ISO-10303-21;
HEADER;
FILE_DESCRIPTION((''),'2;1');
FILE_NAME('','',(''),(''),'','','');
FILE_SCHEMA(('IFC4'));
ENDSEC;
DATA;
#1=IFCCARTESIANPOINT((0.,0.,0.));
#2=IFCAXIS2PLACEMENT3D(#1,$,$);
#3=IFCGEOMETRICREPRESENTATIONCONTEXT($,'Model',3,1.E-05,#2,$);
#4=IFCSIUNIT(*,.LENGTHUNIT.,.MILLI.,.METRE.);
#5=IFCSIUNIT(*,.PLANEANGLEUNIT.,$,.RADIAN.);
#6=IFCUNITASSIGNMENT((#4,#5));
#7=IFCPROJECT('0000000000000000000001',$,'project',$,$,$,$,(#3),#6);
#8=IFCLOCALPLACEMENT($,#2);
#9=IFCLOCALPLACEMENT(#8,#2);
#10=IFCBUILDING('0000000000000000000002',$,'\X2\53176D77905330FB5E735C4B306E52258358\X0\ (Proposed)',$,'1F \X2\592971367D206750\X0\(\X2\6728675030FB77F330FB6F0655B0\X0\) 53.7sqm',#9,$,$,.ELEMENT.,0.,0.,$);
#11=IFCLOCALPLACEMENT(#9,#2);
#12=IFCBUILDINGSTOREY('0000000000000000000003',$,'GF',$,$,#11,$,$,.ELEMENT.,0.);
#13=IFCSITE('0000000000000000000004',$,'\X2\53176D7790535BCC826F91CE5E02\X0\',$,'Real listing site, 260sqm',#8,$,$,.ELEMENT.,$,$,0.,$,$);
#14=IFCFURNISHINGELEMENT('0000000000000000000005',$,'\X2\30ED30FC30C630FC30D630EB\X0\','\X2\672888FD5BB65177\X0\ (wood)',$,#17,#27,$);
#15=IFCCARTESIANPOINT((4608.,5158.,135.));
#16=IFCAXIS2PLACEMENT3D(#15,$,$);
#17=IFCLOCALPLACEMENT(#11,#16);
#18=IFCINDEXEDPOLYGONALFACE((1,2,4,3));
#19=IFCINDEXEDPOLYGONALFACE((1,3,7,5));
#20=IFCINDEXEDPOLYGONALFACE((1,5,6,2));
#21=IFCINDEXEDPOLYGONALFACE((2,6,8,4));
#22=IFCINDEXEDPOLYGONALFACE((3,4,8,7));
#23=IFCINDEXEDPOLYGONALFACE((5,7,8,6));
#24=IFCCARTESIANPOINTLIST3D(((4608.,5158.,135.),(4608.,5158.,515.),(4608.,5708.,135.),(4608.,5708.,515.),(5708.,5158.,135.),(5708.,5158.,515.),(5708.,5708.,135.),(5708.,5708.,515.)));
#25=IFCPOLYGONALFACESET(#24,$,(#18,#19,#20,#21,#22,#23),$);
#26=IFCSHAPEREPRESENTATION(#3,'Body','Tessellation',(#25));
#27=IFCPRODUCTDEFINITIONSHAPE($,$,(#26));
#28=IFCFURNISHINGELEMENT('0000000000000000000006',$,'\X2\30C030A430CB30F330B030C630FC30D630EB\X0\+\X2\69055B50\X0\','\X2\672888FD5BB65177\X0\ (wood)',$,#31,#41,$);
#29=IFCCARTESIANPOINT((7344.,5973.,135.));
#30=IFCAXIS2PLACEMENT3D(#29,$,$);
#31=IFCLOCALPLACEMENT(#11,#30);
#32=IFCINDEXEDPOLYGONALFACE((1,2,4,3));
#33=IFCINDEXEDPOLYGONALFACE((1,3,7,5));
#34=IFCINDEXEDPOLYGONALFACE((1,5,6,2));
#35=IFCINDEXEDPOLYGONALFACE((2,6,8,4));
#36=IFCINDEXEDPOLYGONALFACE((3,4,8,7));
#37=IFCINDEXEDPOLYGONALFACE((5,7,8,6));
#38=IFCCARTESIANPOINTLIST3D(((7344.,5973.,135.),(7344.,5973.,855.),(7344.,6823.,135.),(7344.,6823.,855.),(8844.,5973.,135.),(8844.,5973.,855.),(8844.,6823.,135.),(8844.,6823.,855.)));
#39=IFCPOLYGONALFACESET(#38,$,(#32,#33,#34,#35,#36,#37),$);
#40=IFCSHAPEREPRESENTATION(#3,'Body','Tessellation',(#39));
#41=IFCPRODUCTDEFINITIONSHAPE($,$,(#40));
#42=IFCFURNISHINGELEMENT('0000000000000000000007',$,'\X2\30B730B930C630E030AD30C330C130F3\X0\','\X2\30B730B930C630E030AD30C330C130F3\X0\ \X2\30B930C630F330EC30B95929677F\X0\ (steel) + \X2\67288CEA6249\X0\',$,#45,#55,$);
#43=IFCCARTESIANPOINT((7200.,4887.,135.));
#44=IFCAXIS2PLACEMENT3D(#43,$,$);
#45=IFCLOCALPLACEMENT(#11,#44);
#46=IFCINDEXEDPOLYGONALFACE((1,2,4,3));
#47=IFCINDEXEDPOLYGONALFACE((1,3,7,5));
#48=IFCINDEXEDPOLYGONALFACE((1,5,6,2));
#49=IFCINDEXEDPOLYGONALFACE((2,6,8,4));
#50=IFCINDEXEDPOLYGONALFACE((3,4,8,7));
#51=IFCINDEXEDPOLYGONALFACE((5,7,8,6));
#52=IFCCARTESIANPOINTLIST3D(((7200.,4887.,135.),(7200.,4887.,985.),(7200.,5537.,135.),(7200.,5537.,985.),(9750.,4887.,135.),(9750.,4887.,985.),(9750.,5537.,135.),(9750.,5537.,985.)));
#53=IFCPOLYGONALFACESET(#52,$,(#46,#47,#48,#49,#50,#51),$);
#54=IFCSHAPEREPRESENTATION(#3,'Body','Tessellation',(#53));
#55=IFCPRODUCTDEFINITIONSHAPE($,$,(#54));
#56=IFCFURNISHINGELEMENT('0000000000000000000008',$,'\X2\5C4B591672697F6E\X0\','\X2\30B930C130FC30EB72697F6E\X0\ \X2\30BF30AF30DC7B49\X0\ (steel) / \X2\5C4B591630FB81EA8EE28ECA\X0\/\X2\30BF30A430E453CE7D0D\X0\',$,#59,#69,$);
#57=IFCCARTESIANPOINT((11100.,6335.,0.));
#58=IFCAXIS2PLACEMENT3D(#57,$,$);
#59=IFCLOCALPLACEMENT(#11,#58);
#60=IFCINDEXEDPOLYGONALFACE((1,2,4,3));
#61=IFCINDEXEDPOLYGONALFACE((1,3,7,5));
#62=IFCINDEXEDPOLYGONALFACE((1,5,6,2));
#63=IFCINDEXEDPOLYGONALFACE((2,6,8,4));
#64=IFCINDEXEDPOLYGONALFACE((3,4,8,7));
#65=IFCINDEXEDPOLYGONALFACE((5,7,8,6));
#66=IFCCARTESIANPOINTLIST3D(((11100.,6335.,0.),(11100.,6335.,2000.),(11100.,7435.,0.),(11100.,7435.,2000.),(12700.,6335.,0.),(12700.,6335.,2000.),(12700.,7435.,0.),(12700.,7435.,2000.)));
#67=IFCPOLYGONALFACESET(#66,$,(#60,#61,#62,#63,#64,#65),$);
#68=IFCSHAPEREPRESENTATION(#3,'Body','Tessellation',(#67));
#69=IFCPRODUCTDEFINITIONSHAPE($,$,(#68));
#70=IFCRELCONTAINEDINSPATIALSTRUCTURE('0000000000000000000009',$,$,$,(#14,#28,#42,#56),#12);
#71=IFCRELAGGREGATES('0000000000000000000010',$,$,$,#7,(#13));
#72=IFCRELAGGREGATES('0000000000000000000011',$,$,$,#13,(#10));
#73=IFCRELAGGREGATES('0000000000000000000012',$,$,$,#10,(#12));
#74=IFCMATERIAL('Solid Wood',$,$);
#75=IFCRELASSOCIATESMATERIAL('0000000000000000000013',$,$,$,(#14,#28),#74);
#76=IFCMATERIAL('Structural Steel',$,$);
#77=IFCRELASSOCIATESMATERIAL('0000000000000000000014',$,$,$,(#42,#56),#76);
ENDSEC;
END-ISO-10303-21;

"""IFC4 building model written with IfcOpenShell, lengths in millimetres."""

from ifc_helpers import new_model, si_unit, frame, frame_2d, origin, place, context, project, spatial, rectangle, extrude, material, element, save


model = new_model("IFC4")

# Units and contexts
model_context = context("Model", 3, precision=1e-05, world=origin())
ifc_project = project(units=[si_unit("LENGTHUNIT", "METRE", prefix="MILLI"), si_unit("PLANEANGLEUNIT", "RADIAN")], contexts=[model_context])

# Site, building, storey
site_placement = place(None, origin())
site = spatial("IfcSite", under=ifc_project, at=site_placement, Name="北海道富良野市", ObjectType="Real listing site, 260sqm", CompositionType="ELEMENT", RefElevation=0.0)
building_placement = place(site_placement, origin())
building = spatial("IfcBuilding", under=site, at=building_placement, Name="北海道・平屋の別荘 (Proposed)", ObjectType="1F 天然素材(木材・石・漆喰) 53.7sqm", CompositionType="ELEMENT", ElevationOfRefHeight=0.0, ElevationOfTerrain=0.0)
storey_placement = place(building_placement, origin())
storey = spatial("IfcBuildingStorey", under=building, at=storey_placement, Name="GF", CompositionType="ELEMENT", Elevation=0.0)

# Shared definitions
ifc_material_1 = material(Name="Solid Wood")

# Shared definitions
ifc_material_2 = material(Name="Structural Steel")

# Furnishing elements
furnishing_1_placement = place(storey_placement, frame((4608.0, 5158.0, 135.0)))
element("IfcFurnishingElement", 1, at=furnishing_1_placement, inside=storey, material=ifc_material_1, Name="ローテーブル", Description="木製家具 (wood)", context=model_context, shape_type="SweptSolid", body=[
    extrude(rectangle(XDim=1100.0, YDim=550.0, at=frame_2d((550.0, 275.0))), frame((4608.0, 5158.0, 135.0)), (0.0, 0.0, 1.0), 380.0),
])
furnishing_2_placement = place(storey_placement, frame((7344.0, 5973.0, 135.0)))
element("IfcFurnishingElement", 2, at=furnishing_2_placement, inside=storey, material=ifc_material_1, Name="ダイニングテーブル+椅子", Description="木製家具 (wood)", context=model_context, shape_type="SweptSolid", body=[
    extrude(rectangle(XDim=1500.0, YDim=850.0, at=frame_2d((750.0, 425.0))), frame((7344.0, 5973.0, 135.0)), (0.0, 0.0, 1.0), 720.0),
])
furnishing_3_placement = place(storey_placement, frame((7200.0, 4887.0, 135.0)))
element("IfcFurnishingElement", 3, at=furnishing_3_placement, inside=storey, material=ifc_material_2, Name="システムキッチン", Description="システムキッチン ステンレス天板 (steel) + 木質扉", context=model_context, shape_type="SweptSolid", body=[
    extrude(rectangle(XDim=2550.0, YDim=650.0, at=frame_2d((1275.0, 325.0))), frame((7200.0, 4887.0, 135.0)), (0.0, 0.0, 1.0), 850.0),
])
furnishing_4_placement = place(storey_placement, frame((11100.0, 6335.0, 0.0)))
element("IfcFurnishingElement", 4, at=furnishing_4_placement, inside=storey, material=ifc_material_2, Name="屋外物置", Description="スチール物置 タクボ等 (steel) / 屋外・自転車/タイヤ収納", context=model_context, shape_type="SweptSolid", body=[
    extrude(rectangle(XDim=1600.0, YDim=1100.0, at=frame_2d((800.0, 550.0))), frame((11100.0, 6335.0, 0.0)), (0.0, 0.0, 1.0), 2000.0),
])

save(model, "model.ifc")
